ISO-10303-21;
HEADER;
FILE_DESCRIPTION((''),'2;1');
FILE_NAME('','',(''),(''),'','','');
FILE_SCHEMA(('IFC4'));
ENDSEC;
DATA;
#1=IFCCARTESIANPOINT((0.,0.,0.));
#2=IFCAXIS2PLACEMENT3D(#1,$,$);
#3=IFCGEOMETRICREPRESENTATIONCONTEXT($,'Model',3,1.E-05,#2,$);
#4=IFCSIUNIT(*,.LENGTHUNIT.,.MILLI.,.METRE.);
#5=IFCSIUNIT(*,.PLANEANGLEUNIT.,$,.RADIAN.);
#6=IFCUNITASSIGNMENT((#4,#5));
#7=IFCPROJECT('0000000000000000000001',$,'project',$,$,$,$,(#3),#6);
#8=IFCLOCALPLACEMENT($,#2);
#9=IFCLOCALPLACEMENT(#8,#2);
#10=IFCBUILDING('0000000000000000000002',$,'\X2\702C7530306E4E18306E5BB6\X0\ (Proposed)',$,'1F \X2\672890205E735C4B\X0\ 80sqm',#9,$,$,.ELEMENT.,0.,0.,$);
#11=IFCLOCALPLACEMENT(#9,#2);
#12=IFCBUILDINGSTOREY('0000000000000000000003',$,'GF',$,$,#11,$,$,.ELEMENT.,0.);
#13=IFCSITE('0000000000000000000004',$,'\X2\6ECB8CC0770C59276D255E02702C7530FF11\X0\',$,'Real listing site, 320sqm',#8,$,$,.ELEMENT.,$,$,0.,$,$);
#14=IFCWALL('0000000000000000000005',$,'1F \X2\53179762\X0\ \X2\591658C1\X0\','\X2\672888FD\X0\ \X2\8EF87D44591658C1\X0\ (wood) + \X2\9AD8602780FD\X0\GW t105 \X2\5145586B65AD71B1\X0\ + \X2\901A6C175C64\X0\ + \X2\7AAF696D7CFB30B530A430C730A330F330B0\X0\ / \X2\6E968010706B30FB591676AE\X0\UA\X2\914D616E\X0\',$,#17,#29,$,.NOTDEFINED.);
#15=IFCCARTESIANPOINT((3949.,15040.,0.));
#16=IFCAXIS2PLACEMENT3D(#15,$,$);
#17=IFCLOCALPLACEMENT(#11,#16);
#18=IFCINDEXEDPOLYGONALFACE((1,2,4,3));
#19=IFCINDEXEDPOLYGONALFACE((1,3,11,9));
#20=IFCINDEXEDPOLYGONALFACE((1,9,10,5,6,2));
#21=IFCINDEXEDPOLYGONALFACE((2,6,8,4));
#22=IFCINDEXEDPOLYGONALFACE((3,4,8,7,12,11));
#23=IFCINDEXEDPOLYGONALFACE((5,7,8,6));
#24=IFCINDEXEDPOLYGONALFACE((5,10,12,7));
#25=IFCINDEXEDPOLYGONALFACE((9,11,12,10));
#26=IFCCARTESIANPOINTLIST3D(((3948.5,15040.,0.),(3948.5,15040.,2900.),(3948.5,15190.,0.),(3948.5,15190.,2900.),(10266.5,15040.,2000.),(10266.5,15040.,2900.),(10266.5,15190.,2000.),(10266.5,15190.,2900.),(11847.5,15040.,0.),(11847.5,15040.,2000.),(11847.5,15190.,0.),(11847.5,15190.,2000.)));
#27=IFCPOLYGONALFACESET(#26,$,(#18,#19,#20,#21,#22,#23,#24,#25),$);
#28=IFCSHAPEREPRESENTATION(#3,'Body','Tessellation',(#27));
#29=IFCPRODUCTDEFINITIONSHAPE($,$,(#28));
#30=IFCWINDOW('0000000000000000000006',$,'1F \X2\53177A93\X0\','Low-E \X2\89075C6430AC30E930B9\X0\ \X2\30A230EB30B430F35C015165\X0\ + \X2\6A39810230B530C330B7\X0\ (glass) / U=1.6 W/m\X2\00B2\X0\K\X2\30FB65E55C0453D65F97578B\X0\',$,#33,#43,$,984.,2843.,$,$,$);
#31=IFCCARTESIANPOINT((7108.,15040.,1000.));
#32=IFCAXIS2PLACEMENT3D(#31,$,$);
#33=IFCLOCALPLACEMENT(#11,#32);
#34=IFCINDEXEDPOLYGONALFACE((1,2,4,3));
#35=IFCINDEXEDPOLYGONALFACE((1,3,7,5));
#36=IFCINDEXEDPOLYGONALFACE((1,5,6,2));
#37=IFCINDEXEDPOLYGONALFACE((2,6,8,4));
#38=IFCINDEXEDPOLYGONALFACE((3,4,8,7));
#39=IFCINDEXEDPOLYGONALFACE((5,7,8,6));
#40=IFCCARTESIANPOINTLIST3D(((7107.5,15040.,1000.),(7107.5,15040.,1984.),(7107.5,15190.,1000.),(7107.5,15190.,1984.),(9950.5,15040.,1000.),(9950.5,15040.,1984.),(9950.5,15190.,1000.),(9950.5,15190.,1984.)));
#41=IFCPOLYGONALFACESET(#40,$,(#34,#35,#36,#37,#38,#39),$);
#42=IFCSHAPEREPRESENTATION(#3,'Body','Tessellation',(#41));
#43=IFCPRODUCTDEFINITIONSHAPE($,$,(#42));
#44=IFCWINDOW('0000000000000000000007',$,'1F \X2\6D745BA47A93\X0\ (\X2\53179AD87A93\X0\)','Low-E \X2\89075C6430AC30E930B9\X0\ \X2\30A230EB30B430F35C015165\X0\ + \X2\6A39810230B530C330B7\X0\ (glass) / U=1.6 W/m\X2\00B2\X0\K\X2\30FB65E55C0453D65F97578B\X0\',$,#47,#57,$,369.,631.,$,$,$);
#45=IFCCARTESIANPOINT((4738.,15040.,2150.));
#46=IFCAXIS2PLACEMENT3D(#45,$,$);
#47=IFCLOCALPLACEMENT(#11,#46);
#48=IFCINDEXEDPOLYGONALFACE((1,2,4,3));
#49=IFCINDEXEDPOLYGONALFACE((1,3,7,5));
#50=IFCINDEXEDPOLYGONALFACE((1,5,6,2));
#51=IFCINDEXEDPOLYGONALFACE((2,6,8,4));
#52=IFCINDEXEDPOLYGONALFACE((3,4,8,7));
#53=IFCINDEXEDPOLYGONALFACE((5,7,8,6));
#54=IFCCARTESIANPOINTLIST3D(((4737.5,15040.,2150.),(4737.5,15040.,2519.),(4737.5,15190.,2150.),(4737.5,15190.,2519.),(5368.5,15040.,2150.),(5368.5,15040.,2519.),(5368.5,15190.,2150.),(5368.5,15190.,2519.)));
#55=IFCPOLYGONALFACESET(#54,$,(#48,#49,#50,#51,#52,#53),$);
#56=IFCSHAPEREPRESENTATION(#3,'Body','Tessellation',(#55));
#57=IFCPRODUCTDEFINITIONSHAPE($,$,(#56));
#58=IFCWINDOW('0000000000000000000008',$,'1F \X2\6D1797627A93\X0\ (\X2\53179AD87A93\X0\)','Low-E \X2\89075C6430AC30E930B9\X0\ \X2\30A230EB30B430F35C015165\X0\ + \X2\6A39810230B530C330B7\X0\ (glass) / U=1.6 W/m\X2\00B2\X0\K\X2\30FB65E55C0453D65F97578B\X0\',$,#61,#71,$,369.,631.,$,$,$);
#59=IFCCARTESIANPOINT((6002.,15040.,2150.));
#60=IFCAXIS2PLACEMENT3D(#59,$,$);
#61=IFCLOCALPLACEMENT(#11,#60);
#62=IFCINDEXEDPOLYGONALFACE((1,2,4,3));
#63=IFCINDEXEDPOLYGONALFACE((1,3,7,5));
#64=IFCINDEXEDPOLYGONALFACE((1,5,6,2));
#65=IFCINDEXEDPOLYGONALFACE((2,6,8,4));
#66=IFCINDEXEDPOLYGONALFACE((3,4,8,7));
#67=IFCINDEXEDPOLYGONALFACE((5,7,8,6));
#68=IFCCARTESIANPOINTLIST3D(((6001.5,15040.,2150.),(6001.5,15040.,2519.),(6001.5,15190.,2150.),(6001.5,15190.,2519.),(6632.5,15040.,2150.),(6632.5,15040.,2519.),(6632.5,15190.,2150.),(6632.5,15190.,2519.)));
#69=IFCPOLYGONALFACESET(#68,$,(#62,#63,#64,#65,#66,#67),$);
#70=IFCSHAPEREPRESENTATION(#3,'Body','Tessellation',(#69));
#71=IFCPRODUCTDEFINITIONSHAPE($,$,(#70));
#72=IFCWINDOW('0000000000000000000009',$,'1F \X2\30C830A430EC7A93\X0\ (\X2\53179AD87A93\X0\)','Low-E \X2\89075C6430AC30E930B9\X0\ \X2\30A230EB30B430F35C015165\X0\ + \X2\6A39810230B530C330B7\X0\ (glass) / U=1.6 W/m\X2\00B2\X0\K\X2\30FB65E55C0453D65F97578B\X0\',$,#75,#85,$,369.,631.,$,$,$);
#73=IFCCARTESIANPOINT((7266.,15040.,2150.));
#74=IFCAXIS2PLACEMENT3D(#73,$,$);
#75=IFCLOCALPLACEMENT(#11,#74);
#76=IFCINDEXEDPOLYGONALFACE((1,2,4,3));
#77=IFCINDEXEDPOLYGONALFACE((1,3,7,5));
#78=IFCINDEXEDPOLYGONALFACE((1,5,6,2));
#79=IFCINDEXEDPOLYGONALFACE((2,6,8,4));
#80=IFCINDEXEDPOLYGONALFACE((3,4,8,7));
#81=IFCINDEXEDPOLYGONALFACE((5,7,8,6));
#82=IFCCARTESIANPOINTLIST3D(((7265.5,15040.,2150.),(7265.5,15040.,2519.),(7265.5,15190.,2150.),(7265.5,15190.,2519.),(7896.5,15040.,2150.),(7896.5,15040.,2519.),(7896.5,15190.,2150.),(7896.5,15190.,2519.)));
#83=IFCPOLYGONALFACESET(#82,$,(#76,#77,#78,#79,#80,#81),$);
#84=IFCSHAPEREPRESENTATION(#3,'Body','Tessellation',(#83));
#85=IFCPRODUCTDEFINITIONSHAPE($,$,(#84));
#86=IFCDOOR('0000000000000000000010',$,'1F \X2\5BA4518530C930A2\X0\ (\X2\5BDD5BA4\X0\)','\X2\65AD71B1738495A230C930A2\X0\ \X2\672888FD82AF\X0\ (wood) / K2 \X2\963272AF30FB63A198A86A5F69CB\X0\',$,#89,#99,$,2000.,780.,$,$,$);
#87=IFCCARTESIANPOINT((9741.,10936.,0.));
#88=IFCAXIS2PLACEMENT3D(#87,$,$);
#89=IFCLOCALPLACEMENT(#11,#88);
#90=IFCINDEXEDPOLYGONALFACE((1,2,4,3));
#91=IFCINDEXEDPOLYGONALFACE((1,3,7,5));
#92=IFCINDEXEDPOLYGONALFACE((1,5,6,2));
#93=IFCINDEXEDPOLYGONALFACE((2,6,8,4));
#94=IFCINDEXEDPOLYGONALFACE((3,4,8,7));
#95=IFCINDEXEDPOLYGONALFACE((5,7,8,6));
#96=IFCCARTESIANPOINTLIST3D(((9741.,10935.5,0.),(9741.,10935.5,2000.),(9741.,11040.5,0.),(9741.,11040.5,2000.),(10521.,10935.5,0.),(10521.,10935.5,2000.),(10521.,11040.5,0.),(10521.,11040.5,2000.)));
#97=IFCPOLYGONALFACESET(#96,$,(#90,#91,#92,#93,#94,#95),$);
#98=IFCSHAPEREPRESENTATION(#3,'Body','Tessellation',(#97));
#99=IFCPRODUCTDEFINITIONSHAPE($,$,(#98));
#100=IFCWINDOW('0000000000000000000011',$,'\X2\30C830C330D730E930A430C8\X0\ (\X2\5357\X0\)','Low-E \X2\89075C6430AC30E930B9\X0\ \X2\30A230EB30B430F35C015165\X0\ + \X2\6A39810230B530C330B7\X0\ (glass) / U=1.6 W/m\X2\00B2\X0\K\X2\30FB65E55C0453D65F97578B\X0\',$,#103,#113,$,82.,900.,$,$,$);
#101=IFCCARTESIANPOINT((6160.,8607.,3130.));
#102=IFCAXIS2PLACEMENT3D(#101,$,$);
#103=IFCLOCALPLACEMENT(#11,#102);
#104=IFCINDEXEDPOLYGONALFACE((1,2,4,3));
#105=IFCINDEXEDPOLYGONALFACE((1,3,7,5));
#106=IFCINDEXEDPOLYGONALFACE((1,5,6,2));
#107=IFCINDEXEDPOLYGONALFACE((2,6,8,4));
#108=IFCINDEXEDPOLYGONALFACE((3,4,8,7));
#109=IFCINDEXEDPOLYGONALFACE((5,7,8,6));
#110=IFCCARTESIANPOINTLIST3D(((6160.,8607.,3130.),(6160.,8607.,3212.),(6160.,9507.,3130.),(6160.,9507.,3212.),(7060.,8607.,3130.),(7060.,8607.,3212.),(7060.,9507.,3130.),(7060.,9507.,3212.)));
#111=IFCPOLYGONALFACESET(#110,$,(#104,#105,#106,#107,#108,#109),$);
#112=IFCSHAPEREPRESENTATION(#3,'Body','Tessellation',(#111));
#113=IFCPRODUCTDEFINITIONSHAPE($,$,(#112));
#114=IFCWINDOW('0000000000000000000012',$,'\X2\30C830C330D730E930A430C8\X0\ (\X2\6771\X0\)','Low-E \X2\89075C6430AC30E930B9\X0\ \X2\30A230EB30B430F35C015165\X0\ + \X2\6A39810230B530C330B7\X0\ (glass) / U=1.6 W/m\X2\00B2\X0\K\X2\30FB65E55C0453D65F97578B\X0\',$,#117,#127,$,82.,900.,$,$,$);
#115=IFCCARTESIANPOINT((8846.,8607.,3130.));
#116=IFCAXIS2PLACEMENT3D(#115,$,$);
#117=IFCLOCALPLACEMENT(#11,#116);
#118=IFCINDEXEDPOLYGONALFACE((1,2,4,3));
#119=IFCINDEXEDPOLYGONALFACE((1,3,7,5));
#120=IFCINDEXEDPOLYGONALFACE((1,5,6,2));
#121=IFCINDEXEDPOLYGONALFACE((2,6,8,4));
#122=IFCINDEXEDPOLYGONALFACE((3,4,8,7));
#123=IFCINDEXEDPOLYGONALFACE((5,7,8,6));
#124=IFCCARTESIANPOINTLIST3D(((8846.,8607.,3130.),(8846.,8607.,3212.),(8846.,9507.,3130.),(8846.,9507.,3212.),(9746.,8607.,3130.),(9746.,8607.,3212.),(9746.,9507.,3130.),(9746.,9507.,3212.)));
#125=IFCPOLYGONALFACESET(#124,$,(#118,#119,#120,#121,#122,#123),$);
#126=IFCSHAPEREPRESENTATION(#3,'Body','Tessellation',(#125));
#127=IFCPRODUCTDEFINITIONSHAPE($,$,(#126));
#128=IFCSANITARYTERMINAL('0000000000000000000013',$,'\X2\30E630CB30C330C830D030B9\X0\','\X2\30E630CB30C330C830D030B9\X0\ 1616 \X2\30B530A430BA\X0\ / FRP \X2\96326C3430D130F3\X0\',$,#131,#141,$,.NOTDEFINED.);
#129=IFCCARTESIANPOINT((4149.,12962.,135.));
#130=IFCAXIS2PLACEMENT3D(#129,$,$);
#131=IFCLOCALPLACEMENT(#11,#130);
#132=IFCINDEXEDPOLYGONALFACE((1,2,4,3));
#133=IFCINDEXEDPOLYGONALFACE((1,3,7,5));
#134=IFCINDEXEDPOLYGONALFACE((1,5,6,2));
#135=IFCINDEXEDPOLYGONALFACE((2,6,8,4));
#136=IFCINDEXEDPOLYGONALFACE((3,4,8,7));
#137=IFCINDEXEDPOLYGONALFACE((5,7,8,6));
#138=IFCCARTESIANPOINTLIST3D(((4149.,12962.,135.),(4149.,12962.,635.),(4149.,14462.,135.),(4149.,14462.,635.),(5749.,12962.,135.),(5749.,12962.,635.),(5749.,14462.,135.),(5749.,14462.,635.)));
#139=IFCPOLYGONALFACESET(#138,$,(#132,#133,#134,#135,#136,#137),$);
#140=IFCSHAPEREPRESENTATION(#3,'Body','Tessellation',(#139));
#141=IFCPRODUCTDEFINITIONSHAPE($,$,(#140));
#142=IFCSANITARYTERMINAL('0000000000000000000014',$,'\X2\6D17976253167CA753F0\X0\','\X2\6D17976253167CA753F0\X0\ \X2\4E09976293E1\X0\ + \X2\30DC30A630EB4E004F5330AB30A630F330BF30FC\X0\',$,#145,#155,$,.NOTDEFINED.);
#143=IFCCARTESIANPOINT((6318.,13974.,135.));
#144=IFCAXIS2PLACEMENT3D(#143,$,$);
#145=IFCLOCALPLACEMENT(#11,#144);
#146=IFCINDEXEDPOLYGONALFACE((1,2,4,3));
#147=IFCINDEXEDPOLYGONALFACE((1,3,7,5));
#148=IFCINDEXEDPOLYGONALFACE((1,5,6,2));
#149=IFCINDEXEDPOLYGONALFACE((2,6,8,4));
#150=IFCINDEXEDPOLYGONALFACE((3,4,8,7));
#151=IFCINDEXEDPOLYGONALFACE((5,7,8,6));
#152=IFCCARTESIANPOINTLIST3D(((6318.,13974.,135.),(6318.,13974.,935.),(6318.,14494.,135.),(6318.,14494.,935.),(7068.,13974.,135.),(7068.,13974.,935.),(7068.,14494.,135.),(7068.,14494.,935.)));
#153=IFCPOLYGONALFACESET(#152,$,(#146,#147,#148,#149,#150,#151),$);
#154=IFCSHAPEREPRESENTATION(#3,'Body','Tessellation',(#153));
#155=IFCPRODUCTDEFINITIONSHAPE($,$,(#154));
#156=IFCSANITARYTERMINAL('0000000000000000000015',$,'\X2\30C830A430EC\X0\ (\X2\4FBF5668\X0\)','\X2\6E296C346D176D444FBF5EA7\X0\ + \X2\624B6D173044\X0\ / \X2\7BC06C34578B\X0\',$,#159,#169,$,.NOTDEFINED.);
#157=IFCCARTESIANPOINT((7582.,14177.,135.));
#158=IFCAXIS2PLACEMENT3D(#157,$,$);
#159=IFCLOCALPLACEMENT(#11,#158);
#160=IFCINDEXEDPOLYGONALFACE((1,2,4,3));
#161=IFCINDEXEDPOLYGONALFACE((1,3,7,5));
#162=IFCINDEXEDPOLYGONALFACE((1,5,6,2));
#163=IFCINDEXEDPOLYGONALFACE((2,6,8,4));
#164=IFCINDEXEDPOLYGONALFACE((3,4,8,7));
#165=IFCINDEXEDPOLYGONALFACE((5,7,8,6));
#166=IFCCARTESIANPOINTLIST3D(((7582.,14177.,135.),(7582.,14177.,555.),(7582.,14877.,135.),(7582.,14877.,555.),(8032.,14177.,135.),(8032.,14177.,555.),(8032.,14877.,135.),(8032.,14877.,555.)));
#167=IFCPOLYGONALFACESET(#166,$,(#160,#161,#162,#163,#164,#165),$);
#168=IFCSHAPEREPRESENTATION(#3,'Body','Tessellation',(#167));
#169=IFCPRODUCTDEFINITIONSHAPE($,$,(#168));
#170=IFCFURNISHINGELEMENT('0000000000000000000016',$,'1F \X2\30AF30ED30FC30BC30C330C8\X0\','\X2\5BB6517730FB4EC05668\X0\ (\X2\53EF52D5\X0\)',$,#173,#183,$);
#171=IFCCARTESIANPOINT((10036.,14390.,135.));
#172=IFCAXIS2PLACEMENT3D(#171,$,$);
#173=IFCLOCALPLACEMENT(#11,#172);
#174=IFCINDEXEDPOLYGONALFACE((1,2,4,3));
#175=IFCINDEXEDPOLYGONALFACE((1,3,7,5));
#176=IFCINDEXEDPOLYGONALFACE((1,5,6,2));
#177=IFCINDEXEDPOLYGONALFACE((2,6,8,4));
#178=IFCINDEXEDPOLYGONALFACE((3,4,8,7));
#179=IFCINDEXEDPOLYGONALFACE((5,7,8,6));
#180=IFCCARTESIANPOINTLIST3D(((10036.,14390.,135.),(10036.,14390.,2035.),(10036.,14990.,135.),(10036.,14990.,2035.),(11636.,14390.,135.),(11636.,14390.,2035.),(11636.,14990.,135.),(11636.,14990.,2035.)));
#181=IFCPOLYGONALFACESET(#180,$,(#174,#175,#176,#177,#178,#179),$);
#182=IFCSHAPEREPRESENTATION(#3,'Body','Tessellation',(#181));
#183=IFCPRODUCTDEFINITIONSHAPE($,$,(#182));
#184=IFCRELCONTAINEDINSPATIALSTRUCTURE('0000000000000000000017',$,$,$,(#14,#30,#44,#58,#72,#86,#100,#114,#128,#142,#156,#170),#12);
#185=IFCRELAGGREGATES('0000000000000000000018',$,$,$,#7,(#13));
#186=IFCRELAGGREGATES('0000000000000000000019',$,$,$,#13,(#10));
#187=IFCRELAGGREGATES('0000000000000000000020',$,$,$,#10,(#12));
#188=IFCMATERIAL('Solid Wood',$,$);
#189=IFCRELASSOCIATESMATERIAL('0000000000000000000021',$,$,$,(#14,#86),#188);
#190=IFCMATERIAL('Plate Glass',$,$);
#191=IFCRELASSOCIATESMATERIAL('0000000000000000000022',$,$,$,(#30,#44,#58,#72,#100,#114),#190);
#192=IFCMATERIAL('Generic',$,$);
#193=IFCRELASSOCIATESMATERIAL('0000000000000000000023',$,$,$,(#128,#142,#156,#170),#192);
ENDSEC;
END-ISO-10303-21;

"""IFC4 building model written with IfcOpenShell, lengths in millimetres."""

from ifc_helpers import new_model, si_unit, frame, frame_2d, origin, place, context, project, spatial, rectangle, extrude, material, element, fill, save


model = new_model("IFC4")

# Units and contexts
model_context = context("Model", 3, precision=1e-05, world=origin())
ifc_project = project(units=[si_unit("LENGTHUNIT", "METRE", prefix="MILLI"), si_unit("PLANEANGLEUNIT", "RADIAN")], contexts=[model_context])

# Site, building, storey
site_placement = place(None, origin())
site = spatial("IfcSite", under=ifc_project, at=site_placement, Name="滋賀県大津市瀬田１", ObjectType="Real listing site, 320sqm", CompositionType="ELEMENT", RefElevation=0.0)
building_placement = place(site_placement, origin())
building = spatial("IfcBuilding", under=site, at=building_placement, Name="瀬田の丘の家 (Proposed)", ObjectType="1F 木造平屋 80sqm", CompositionType="ELEMENT", ElevationOfRefHeight=0.0, ElevationOfTerrain=0.0)
storey_placement = place(building_placement, origin())
storey = spatial("IfcBuildingStorey", under=building, at=storey_placement, Name="GF", CompositionType="ELEMENT", Elevation=0.0)

# Shared definitions
ifc_material_1 = material(Name="Solid Wood")

# Wall, openings, windows
wall_1_placement = place(storey_placement, frame((3949.0, 15040.0, 0.0)))
wall_1 = element("IfcWall", 1, at=wall_1_placement, inside=storey, material=ifc_material_1, Name="1F 北面 外壁", Description="木製 軸組外壁 (wood) + 高性能GW t105 充填断熱 + 通気層 + 窯業系サイディング / 準耐火・外皮UA配慮", PredefinedType="NOTDEFINED", context=model_context, shape_type="SweptSolid", body=[
    extrude(rectangle(XDim=7899.0, YDim=150.0, at=frame_2d((3949.0, 75.0))), frame((3949.0, 15040.0, 0.0)), (0.0, 0.0, 1.0), 2900.0),
])
opening_1_placement = place(storey_placement, frame((7108.0, 15040.0, 1000.0)))
opening_1 = element("IfcOpeningElement", 2, at=opening_1_placement, cuts=wall_1, PredefinedType="NOTDEFINED", context=model_context, shape_type="SweptSolid", body=[
    extrude(rectangle(XDim=2843.0, YDim=150.0, at=frame_2d((1421.0, 75.0))), frame((7108.0, 15040.0, 1000.0)), (0.0, 0.0, 1.0), 984.0),
])
opening_2_placement = place(storey_placement, frame((4738.0, 15040.0, 2150.0)))
opening_2 = element("IfcOpeningElement", 3, at=opening_2_placement, cuts=wall_1, PredefinedType="NOTDEFINED", context=model_context, shape_type="SweptSolid", body=[
    extrude(rectangle(XDim=631.0, YDim=150.0, at=frame_2d((315.0, 75.0))), frame((4738.0, 15040.0, 2150.0)), (0.0, 0.0, 1.0), 369.0),
])
opening_3_placement = place(storey_placement, frame((6002.0, 15040.0, 2150.0)))
opening_3 = element("IfcOpeningElement", 4, at=opening_3_placement, cuts=wall_1, PredefinedType="NOTDEFINED", context=model_context, shape_type="SweptSolid", body=[
    extrude(rectangle(XDim=631.0, YDim=150.0, at=frame_2d((315.0, 75.0))), frame((6002.0, 15040.0, 2150.0)), (0.0, 0.0, 1.0), 369.0),
])
opening_4_placement = place(storey_placement, frame((7266.0, 15040.0, 2150.0)))
opening_4 = element("IfcOpeningElement", 5, at=opening_4_placement, cuts=wall_1, PredefinedType="NOTDEFINED", context=model_context, shape_type="SweptSolid", body=[
    extrude(rectangle(XDim=631.0, YDim=150.0, at=frame_2d((315.0, 75.0))), frame((7266.0, 15040.0, 2150.0)), (0.0, 0.0, 1.0), 369.0),
])
ifc_material_2 = material(Name="Plate Glass")
window_1_placement = place(storey_placement, frame((7108.0, 15040.0, 1000.0)))
window_1 = element("IfcWindow", 6, at=window_1_placement, inside=storey, material=ifc_material_2, Name="1F 北窓", Description="Low-E 複層ガラス アルゴン封入 + 樹脂サッシ (glass) / U=1.6 W/m²K・日射取得型", OverallHeight=984.0, OverallWidth=2843.0, context=model_context, shape_type="SweptSolid", body=[
    extrude(rectangle(XDim=2843.0, YDim=150.0, at=frame_2d((1421.0, 75.0))), frame((7108.0, 15040.0, 1000.0)), (0.0, 0.0, 1.0), 984.0),
])
fill(opening_1, window_1)
window_2_placement = place(storey_placement, frame((4738.0, 15040.0, 2150.0)))
window_2 = element("IfcWindow", 7, at=window_2_placement, inside=storey, material=ifc_material_2, Name="1F 浴室窓 (北高窓)", Description="Low-E 複層ガラス アルゴン封入 + 樹脂サッシ (glass) / U=1.6 W/m²K・日射取得型", OverallHeight=369.0, OverallWidth=631.0, context=model_context, shape_type="SweptSolid", body=[
    extrude(rectangle(XDim=631.0, YDim=150.0, at=frame_2d((315.0, 75.0))), frame((4738.0, 15040.0, 2150.0)), (0.0, 0.0, 1.0), 369.0),
])
fill(opening_2, window_2)
window_3_placement = place(storey_placement, frame((6002.0, 15040.0, 2150.0)))
window_3 = element("IfcWindow", 8, at=window_3_placement, inside=storey, material=ifc_material_2, Name="1F 洗面窓 (北高窓)", Description="Low-E 複層ガラス アルゴン封入 + 樹脂サッシ (glass) / U=1.6 W/m²K・日射取得型", OverallHeight=369.0, OverallWidth=631.0, context=model_context, shape_type="SweptSolid", body=[
    extrude(rectangle(XDim=631.0, YDim=150.0, at=frame_2d((315.0, 75.0))), frame((6002.0, 15040.0, 2150.0)), (0.0, 0.0, 1.0), 369.0),
])
fill(opening_3, window_3)
window_4_placement = place(storey_placement, frame((7266.0, 15040.0, 2150.0)))
window_4 = element("IfcWindow", 9, at=window_4_placement, inside=storey, material=ifc_material_2, Name="1F トイレ窓 (北高窓)", Description="Low-E 複層ガラス アルゴン封入 + 樹脂サッシ (glass) / U=1.6 W/m²K・日射取得型", OverallHeight=369.0, OverallWidth=631.0, context=model_context, shape_type="SweptSolid", body=[
    extrude(rectangle(XDim=631.0, YDim=150.0, at=frame_2d((315.0, 75.0))), frame((7266.0, 15040.0, 2150.0)), (0.0, 0.0, 1.0), 369.0),
])
fill(opening_4, window_4)

# Door
door_1_placement = place(storey_placement, frame((9741.0, 10936.0, 0.0)))
element("IfcDoor", 10, at=door_1_placement, inside=storey, material=ifc_material_1, Name="1F 室内ドア (寝室)", Description="断熱玄関ドア 木製芯 (wood) / K2 防犯・採風機構", OverallHeight=2000.0, OverallWidth=780.0, context=model_context, shape_type="SweptSolid", body=[
    extrude(rectangle(XDim=780.0, YDim=105.0, at=frame_2d((390.0, 52.0))), frame((9741.0, 10936.0, 0.0)), (0.0, 0.0, 1.0), 2000.0),
])

# Windows
window_5_placement = place(storey_placement, frame((6160.0, 8607.0, 3130.0)))
element("IfcWindow", 11, at=window_5_placement, inside=storey, material=ifc_material_2, Name="トップライト (南)", Description="Low-E 複層ガラス アルゴン封入 + 樹脂サッシ (glass) / U=1.6 W/m²K・日射取得型", OverallHeight=82.0, OverallWidth=900.0, context=model_context, shape_type="SweptSolid", body=[
    extrude(rectangle(XDim=900.0, YDim=900.0, at=frame_2d((450.0, 450.0))), frame((6160.0, 8607.0, 3130.0)), (0.0, 0.0, 1.0), 82.0),
])
window_6_placement = place(storey_placement, frame((8846.0, 8607.0, 3130.0)))
element("IfcWindow", 12, at=window_6_placement, inside=storey, material=ifc_material_2, Name="トップライト (東)", Description="Low-E 複層ガラス アルゴン封入 + 樹脂サッシ (glass) / U=1.6 W/m²K・日射取得型", OverallHeight=82.0, OverallWidth=900.0, context=model_context, shape_type="SweptSolid", body=[
    extrude(rectangle(XDim=900.0, YDim=900.0, at=frame_2d((450.0, 450.0))), frame((8846.0, 8607.0, 3130.0)), (0.0, 0.0, 1.0), 82.0),
])

# Sanitary terminals
ifc_material_3 = material(Name="Generic")
sanitary_terminal_1_placement = place(storey_placement, frame((4149.0, 12962.0, 135.0)))
element("IfcSanitaryTerminal", 13, at=sanitary_terminal_1_placement, inside=storey, material=ifc_material_3, Name="ユニットバス", Description="ユニットバス 1616 サイズ / FRP 防水パン", PredefinedType="NOTDEFINED", context=model_context, shape_type="SweptSolid", body=[
    extrude(rectangle(XDim=1600.0, YDim=1500.0, at=frame_2d((800.0, 750.0))), frame((4149.0, 12962.0, 135.0)), (0.0, 0.0, 1.0), 500.0),
])
sanitary_terminal_2_placement = place(storey_placement, frame((6318.0, 13974.0, 135.0)))
element("IfcSanitaryTerminal", 14, at=sanitary_terminal_2_placement, inside=storey, material=ifc_material_3, Name="洗面化粧台", Description="洗面化粧台 三面鏡 + ボウル一体カウンター", PredefinedType="NOTDEFINED", context=model_context, shape_type="SweptSolid", body=[
    extrude(rectangle(XDim=750.0, YDim=520.0, at=frame_2d((375.0, 260.0))), frame((6318.0, 13974.0, 135.0)), (0.0, 0.0, 1.0), 800.0),
])
sanitary_terminal_3_placement = place(storey_placement, frame((7582.0, 14177.0, 135.0)))
element("IfcSanitaryTerminal", 15, at=sanitary_terminal_3_placement, inside=storey, material=ifc_material_3, Name="トイレ (便器)", Description="温水洗浄便座 + 手洗い / 節水型", PredefinedType="NOTDEFINED", context=model_context, shape_type="SweptSolid", body=[
    extrude(rectangle(XDim=450.0, YDim=700.0, at=frame_2d((225.0, 350.0))), frame((7582.0, 14177.0, 135.0)), (0.0, 0.0, 1.0), 420.0),
])

# Furnishing element
furnishing_1_placement = place(storey_placement, frame((10036.0, 14390.0, 135.0)))
element("IfcFurnishingElement", 16, at=furnishing_1_placement, inside=storey, material=ifc_material_3, Name="1F クローゼット", Description="家具・什器 (可動)", context=model_context, shape_type="SweptSolid", body=[
    extrude(rectangle(XDim=1600.0, YDim=600.0, at=frame_2d((800.0, 300.0))), frame((10036.0, 14390.0, 135.0)), (0.0, 0.0, 1.0), 1900.0),
])

save(model, "model.ifc")
